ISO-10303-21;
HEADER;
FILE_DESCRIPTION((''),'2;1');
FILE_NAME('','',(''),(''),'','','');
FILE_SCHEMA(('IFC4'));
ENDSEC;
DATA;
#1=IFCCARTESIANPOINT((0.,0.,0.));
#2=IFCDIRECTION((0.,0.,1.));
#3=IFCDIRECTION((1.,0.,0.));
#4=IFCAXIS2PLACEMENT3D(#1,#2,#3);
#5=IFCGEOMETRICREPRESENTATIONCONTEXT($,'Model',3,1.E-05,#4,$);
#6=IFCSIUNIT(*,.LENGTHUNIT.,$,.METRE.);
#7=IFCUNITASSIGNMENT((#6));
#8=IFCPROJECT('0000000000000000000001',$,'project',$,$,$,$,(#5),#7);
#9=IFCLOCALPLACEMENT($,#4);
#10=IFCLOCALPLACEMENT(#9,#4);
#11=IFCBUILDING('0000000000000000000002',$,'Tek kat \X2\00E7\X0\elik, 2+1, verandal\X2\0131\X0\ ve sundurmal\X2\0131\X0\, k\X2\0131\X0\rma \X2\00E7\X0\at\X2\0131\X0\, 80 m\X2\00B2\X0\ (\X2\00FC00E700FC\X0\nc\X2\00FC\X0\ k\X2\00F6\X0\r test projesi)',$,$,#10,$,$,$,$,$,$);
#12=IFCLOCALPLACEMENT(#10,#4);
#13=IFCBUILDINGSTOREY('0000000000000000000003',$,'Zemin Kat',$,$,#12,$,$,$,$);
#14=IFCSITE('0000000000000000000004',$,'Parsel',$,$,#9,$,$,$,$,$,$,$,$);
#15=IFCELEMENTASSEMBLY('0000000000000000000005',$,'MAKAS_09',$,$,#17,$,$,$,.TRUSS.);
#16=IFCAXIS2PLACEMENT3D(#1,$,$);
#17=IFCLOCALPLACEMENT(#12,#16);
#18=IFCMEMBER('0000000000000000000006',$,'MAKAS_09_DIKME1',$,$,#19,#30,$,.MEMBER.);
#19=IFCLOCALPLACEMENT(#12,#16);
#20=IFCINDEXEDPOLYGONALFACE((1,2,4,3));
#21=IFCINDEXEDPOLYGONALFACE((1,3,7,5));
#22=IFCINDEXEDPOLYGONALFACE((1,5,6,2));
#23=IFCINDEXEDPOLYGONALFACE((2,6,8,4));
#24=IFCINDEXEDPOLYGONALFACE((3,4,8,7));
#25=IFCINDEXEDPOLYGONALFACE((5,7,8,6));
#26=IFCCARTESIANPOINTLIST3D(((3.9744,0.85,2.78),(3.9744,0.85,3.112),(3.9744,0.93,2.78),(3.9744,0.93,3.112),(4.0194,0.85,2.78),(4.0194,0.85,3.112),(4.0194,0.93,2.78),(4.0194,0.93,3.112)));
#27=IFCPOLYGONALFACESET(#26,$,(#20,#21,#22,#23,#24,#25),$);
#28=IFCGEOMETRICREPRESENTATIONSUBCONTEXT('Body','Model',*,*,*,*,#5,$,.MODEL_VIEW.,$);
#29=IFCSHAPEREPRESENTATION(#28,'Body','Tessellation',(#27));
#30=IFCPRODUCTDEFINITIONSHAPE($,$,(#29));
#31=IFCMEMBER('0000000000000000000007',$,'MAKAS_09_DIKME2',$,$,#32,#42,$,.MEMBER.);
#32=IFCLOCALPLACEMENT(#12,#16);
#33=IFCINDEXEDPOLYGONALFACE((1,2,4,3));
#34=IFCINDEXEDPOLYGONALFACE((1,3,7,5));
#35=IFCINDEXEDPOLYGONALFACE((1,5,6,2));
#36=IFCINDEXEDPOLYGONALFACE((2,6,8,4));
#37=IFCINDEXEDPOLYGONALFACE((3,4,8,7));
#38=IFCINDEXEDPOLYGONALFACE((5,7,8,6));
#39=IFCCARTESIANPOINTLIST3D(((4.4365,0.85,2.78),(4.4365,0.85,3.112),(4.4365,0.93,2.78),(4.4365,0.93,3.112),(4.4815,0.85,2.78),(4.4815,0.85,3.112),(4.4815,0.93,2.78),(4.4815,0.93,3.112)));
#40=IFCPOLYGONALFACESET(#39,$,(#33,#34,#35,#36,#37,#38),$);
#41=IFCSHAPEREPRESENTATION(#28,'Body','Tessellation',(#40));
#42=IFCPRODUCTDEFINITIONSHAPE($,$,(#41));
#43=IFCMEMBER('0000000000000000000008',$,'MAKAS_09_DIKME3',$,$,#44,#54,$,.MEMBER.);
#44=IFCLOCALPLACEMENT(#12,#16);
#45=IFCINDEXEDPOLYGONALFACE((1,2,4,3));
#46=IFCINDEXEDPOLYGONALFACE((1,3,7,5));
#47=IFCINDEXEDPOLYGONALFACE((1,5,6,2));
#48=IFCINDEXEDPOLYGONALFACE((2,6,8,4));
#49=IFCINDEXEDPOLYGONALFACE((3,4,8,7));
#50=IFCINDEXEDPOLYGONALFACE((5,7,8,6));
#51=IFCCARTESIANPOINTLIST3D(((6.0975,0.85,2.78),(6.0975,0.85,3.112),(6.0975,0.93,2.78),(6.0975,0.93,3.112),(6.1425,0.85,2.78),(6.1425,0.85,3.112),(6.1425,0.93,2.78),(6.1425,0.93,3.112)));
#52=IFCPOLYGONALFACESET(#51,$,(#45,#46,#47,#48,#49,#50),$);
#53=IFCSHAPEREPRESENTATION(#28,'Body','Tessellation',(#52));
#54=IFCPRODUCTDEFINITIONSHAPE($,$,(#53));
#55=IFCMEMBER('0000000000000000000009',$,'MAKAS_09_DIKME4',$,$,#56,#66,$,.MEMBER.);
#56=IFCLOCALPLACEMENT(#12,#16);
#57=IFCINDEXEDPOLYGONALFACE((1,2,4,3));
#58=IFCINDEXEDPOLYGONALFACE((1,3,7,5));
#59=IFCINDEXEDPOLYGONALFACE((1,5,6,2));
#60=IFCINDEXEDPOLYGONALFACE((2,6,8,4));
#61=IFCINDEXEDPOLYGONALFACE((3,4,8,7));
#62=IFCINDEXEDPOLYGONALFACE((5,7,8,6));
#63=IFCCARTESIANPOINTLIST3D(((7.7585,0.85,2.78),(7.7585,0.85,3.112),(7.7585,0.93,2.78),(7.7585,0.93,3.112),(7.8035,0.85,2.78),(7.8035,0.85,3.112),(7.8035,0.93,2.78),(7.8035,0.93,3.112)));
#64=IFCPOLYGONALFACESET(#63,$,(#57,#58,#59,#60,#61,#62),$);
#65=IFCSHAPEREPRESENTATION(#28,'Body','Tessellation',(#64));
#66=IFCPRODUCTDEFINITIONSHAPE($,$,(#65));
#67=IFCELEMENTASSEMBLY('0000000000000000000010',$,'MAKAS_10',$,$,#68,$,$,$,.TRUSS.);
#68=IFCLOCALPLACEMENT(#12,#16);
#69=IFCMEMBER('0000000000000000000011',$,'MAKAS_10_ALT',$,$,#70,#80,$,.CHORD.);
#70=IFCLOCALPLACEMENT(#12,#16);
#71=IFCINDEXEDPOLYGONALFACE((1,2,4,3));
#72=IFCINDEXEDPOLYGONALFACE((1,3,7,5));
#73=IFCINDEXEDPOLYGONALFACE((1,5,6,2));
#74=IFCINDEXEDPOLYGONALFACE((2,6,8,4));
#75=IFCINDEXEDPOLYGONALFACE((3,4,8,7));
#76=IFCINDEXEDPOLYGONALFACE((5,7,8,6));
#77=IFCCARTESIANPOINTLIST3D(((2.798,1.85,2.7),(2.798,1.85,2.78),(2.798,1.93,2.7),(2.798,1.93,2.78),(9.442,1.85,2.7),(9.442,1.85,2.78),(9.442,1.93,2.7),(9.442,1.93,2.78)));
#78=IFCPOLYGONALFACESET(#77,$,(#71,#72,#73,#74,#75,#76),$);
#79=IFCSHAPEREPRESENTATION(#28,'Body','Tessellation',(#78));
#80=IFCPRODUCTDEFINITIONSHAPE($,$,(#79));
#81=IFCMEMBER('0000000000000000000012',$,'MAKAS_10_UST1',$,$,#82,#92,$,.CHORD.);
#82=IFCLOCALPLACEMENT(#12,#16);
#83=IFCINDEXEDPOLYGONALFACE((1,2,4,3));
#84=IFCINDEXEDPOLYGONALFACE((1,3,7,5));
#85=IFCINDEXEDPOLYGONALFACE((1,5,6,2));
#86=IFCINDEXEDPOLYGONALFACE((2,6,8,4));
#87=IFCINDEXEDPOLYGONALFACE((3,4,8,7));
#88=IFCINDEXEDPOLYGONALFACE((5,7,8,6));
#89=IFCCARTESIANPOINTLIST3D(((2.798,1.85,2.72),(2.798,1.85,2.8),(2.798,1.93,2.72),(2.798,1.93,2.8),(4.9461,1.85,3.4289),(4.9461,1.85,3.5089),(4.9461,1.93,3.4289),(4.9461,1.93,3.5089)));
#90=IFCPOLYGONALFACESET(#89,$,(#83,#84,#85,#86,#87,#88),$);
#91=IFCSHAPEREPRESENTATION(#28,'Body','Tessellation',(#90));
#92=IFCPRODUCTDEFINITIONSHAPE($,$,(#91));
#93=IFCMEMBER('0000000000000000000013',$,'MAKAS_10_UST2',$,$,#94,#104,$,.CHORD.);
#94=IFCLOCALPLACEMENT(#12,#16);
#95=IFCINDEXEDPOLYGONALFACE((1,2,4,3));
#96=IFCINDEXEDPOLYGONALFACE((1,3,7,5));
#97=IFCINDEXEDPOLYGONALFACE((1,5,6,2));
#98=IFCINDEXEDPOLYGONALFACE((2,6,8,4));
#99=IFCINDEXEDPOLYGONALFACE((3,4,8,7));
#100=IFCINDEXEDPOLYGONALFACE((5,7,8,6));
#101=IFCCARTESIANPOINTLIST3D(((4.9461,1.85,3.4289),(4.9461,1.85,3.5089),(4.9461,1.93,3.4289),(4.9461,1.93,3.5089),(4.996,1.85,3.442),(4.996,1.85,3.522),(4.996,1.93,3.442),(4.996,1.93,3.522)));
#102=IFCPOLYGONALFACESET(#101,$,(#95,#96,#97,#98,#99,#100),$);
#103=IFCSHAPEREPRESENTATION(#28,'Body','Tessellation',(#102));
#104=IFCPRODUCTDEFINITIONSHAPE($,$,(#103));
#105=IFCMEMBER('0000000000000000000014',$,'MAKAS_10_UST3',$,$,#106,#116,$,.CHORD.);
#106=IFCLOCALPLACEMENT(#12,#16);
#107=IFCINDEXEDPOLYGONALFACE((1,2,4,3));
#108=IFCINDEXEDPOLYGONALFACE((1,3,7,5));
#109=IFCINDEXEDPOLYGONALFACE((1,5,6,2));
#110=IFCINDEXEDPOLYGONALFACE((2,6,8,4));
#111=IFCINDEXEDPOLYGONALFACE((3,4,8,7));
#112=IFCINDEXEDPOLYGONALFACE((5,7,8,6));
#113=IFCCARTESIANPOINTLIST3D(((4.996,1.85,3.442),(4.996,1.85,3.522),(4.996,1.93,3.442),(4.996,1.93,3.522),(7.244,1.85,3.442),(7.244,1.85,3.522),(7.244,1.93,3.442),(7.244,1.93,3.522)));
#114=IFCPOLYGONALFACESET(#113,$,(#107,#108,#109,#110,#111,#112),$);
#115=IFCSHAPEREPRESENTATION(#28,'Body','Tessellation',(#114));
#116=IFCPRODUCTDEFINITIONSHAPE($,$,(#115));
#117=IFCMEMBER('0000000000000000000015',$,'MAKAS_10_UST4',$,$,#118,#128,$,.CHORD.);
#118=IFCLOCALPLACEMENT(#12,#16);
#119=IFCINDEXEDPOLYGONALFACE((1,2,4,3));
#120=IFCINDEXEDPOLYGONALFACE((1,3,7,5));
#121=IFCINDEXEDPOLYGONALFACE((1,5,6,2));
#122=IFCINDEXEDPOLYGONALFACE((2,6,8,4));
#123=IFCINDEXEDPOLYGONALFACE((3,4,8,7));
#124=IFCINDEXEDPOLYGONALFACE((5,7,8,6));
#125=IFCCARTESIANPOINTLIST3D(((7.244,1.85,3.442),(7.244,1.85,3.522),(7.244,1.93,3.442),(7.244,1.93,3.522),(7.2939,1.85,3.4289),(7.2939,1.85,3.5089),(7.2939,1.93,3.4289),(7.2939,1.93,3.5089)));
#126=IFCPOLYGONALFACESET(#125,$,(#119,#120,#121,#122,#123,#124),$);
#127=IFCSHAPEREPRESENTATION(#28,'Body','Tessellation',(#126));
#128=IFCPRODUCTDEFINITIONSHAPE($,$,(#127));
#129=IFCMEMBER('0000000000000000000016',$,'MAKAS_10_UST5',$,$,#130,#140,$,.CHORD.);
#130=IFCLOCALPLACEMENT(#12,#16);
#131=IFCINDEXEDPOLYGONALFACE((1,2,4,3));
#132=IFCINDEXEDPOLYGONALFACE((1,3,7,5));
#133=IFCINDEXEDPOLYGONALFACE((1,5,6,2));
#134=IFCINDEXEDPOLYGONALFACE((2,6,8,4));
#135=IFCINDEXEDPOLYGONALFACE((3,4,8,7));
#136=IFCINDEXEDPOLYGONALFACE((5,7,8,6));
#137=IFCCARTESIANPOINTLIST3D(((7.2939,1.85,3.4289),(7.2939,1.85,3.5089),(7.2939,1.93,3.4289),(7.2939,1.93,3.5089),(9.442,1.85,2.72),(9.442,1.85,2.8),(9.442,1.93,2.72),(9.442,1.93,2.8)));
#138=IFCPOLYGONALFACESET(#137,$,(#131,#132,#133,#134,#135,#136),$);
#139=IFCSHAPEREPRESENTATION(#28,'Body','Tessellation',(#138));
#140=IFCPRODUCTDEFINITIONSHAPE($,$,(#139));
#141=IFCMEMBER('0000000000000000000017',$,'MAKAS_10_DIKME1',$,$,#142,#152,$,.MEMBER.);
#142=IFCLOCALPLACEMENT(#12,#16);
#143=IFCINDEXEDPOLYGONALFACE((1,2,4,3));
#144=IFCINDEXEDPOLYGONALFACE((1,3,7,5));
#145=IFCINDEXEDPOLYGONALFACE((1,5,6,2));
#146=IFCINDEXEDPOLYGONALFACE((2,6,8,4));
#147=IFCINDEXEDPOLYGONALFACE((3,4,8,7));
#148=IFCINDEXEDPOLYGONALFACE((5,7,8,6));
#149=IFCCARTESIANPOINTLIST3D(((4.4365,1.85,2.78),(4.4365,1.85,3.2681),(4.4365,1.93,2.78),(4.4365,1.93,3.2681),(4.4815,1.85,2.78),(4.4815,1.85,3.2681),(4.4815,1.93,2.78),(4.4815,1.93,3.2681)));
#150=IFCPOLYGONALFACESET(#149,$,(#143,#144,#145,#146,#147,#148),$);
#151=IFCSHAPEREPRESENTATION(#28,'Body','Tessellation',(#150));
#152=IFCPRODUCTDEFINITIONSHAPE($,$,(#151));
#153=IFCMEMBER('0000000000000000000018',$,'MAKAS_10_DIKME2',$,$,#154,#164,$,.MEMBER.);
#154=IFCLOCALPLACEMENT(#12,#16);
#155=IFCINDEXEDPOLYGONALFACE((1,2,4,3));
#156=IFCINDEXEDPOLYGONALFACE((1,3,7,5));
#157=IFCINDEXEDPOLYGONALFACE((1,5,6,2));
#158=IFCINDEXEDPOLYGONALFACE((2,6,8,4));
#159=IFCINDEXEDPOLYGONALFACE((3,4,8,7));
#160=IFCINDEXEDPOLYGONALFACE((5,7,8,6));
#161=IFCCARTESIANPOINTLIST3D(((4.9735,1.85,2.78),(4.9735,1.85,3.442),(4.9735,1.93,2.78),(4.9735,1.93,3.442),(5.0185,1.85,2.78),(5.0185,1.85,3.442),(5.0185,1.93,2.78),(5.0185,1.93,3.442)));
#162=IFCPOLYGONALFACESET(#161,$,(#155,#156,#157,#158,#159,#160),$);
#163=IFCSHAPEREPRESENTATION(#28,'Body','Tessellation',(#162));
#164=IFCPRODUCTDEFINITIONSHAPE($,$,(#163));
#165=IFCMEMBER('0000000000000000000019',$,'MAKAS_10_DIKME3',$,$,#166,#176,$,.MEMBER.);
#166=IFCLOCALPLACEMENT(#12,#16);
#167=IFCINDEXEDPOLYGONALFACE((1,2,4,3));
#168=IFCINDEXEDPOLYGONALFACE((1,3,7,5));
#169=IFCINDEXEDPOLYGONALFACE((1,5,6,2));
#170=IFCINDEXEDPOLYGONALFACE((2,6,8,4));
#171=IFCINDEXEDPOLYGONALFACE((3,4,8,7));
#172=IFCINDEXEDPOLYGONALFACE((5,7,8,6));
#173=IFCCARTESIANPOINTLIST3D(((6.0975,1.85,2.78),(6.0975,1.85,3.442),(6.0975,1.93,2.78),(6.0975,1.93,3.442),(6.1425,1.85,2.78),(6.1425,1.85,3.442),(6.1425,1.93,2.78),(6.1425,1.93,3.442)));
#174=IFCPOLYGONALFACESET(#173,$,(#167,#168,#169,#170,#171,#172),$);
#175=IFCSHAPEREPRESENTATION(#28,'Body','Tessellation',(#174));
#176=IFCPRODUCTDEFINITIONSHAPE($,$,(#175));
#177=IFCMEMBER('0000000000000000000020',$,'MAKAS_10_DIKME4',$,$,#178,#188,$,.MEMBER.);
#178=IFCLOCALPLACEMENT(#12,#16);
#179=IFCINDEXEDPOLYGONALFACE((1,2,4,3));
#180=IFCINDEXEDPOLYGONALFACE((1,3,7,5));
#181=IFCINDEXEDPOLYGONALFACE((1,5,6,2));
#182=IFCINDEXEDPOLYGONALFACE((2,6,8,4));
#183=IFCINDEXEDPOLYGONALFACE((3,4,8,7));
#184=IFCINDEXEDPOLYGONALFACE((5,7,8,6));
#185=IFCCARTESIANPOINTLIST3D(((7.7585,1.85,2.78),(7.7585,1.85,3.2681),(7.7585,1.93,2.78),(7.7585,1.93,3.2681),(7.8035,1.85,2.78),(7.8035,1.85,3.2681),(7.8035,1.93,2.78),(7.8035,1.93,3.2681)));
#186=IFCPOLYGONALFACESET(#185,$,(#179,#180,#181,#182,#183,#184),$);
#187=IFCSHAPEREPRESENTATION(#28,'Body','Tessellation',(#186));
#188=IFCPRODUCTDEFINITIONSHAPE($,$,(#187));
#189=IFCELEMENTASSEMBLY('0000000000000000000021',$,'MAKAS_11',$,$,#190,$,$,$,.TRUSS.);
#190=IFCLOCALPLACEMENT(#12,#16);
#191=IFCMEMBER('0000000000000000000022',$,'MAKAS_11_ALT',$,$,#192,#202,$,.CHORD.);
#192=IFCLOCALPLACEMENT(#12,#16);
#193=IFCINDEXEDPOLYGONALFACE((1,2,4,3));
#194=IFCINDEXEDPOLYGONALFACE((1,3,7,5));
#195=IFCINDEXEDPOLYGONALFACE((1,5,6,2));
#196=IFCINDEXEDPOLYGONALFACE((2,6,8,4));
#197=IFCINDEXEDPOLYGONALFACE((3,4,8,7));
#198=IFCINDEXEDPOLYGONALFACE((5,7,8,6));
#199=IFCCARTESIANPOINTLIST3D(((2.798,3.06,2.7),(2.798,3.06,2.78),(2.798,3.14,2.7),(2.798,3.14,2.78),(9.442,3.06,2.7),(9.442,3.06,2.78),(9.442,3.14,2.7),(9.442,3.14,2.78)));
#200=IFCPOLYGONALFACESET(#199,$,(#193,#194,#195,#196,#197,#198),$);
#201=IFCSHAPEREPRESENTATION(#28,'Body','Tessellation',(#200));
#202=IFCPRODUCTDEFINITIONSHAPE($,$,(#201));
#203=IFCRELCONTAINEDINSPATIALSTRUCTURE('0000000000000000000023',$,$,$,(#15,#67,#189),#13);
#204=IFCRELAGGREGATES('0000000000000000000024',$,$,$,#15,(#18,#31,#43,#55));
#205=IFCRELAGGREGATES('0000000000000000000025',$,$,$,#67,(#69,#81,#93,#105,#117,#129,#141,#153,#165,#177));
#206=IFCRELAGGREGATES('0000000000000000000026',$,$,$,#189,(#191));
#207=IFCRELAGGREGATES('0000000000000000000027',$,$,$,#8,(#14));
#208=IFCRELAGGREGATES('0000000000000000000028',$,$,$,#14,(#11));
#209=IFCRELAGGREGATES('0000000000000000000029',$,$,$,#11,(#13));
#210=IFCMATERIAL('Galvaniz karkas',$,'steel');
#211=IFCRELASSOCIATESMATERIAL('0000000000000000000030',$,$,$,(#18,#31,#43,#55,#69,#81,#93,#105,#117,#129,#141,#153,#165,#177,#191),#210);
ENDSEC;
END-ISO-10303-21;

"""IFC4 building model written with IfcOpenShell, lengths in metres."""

from ifc_helpers import new_model, si_unit, frame, origin_with_axes, place, context, subcontext, project, spatial, line, indexed_curve, outline, extrude, material, element, aggregate, save


model = new_model("IFC4")

# Units and contexts
model_context = context("Model", 3, precision=1e-05, world=origin_with_axes())
body_context = subcontext(model_context, "Body", "Model", "MODEL_VIEW")
ifc_project = project(units=[si_unit("LENGTHUNIT", "METRE")], contexts=[model_context])

# Site, building, storey
site_placement = place(None, origin_with_axes())
site = spatial("IfcSite", under=ifc_project, at=site_placement, Name="Parsel")
building_placement = place(site_placement, origin_with_axes())
building = spatial("IfcBuilding", under=site, at=building_placement, Name="Tek kat çelik, 2+1, verandalı ve sundurmalı, kırma çatı, 80 m² (üçüncü kör test projesi)")
storey_placement = place(building_placement, origin_with_axes())
storey = spatial("IfcBuildingStorey", under=building, at=storey_placement, Name="Zemin Kat")

# Element assemblies, members
ifc_material = material(Name="Galvaniz karkas", Category="steel")
assembly_1_placement = place(storey_placement, origin_with_axes())
assembly_1 = element("IfcElementAssembly", 1, at=assembly_1_placement, inside=storey, Name="MAKAS_09", PredefinedType="TRUSS")
member_1_placement = place(assembly_1_placement, origin_with_axes())
member_1 = element("IfcMember", 2, at=member_1_placement, material=ifc_material, Name="MAKAS_09_DIKME1", PredefinedType="MEMBER", context=body_context, shape_type="SweptSolid", body=[
    extrude(outline(indexed_curve([(3.9744, 2.78), (4.0194, 2.78), (4.0194, 3.112), (3.9744, 3.112)], segments=[line(1, 2, 3, 4, 1)])), frame((0.0, 0.93, 0.0), z_axis=(0.0, -1.0, 0.0), x_axis=(1.0, 0.0, 0.0)), (0.0, 0.0, 1.0), 0.08),
])
member_2_placement = place(assembly_1_placement, origin_with_axes())
member_2 = element("IfcMember", 3, at=member_2_placement, material=ifc_material, Name="MAKAS_09_DIKME2", PredefinedType="MEMBER", context=body_context, shape_type="SweptSolid", body=[
    extrude(outline(indexed_curve([(4.4365, 2.78), (4.4815, 2.78), (4.4815, 3.112), (4.4365, 3.112)], segments=[line(1, 2, 3, 4, 1)])), frame((0.0, 0.93, 0.0), z_axis=(0.0, -1.0, 0.0), x_axis=(1.0, 0.0, 0.0)), (0.0, 0.0, 1.0), 0.08),
])
member_3_placement = place(assembly_1_placement, origin_with_axes())
member_3 = element("IfcMember", 4, at=member_3_placement, material=ifc_material, Name="MAKAS_09_DIKME3", PredefinedType="MEMBER", context=body_context, shape_type="SweptSolid", body=[
    extrude(outline(indexed_curve([(6.0975, 2.78), (6.1425, 2.78), (6.1425, 3.112), (6.0975, 3.112)], segments=[line(1, 2, 3, 4, 1)])), frame((0.0, 0.93, 0.0), z_axis=(0.0, -1.0, 0.0), x_axis=(1.0, 0.0, 0.0)), (0.0, 0.0, 1.0), 0.08),
])
member_4_placement = place(assembly_1_placement, origin_with_axes())
member_4 = element("IfcMember", 5, at=member_4_placement, material=ifc_material, Name="MAKAS_09_DIKME4", PredefinedType="MEMBER", context=body_context, shape_type="SweptSolid", body=[
    extrude(outline(indexed_curve([(7.7585, 2.78), (7.8035, 2.78), (7.8035, 3.112), (7.7585, 3.112)], segments=[line(1, 2, 3, 4, 1)])), frame((0.0, 0.93, 0.0), z_axis=(0.0, -1.0, 0.0), x_axis=(1.0, 0.0, 0.0)), (0.0, 0.0, 1.0), 0.08),
])
aggregate(assembly_1, [member_1, member_2, member_3, member_4])
assembly_2_placement = place(storey_placement, origin_with_axes())
assembly_2 = element("IfcElementAssembly", 6, at=assembly_2_placement, inside=storey, Name="MAKAS_10", PredefinedType="TRUSS")
member_5_placement = place(assembly_2_placement, origin_with_axes())
member_5 = element("IfcMember", 7, at=member_5_placement, material=ifc_material, Name="MAKAS_10_ALT", PredefinedType="CHORD", context=body_context, shape_type="SweptSolid", body=[
    extrude(outline(indexed_curve([(2.798, 2.7), (9.442, 2.7), (9.442, 2.78), (2.798, 2.78)], segments=[line(1, 2, 3, 4, 1)])), frame((0.0, 1.93, 0.0), z_axis=(0.0, -1.0, 0.0), x_axis=(1.0, 0.0, 0.0)), (0.0, 0.0, 1.0), 0.08),
])
member_6_placement = place(assembly_2_placement, origin_with_axes())
member_6 = element("IfcMember", 8, at=member_6_placement, material=ifc_material, Name="MAKAS_10_UST1", PredefinedType="CHORD", context=body_context, shape_type="SweptSolid", body=[
    extrude(outline(indexed_curve([(2.798, 2.72), (4.9461, 3.4289), (4.9461, 3.5089), (2.798, 2.8)], segments=[line(1, 2, 3, 4, 1)])), frame((0.0, 1.93, 0.0), z_axis=(0.0, -1.0, 0.0), x_axis=(1.0, 0.0, 0.0)), (0.0, 0.0, 1.0), 0.08),
])
member_7_placement = place(assembly_2_placement, origin_with_axes())
member_7 = element("IfcMember", 9, at=member_7_placement, material=ifc_material, Name="MAKAS_10_UST2", PredefinedType="CHORD", context=body_context, shape_type="SweptSolid", body=[
    extrude(outline(indexed_curve([(4.9461, 3.4289), (4.996, 3.442), (4.996, 3.522), (4.9461, 3.5089)], segments=[line(1, 2, 3, 4, 1)])), frame((0.0, 1.93, 0.0), z_axis=(0.0, -1.0, 0.0), x_axis=(1.0, 0.0, 0.0)), (0.0, 0.0, 1.0), 0.08),
])
member_8_placement = place(assembly_2_placement, origin_with_axes())
member_8 = element("IfcMember", 10, at=member_8_placement, material=ifc_material, Name="MAKAS_10_UST3", PredefinedType="CHORD", context=body_context, shape_type="SweptSolid", body=[
    extrude(outline(indexed_curve([(4.996, 3.442), (7.244, 3.442), (7.244, 3.522), (4.996, 3.522)], segments=[line(1, 2, 3, 4, 1)])), frame((0.0, 1.93, 0.0), z_axis=(0.0, -1.0, 0.0), x_axis=(1.0, 0.0, 0.0)), (0.0, 0.0, 1.0), 0.08),
])
member_9_placement = place(assembly_2_placement, origin_with_axes())
member_9 = element("IfcMember", 11, at=member_9_placement, material=ifc_material, Name="MAKAS_10_UST4", PredefinedType="CHORD", context=body_context, shape_type="SweptSolid", body=[
    extrude(outline(indexed_curve([(7.244, 3.442), (7.2939, 3.4289), (7.2939, 3.5089), (7.244, 3.522)], segments=[line(1, 2, 3, 4, 1)])), frame((0.0, 1.93, 0.0), z_axis=(0.0, -1.0, 0.0), x_axis=(1.0, 0.0, 0.0)), (0.0, 0.0, 1.0), 0.08),
])
member_10_placement = place(assembly_2_placement, origin_with_axes())
member_10 = element("IfcMember", 12, at=member_10_placement, material=ifc_material, Name="MAKAS_10_UST5", PredefinedType="CHORD", context=body_context, shape_type="SweptSolid", body=[
    extrude(outline(indexed_curve([(7.2939, 3.4289), (9.442, 2.72), (9.442, 2.8), (7.2939, 3.5089)], segments=[line(1, 2, 3, 4, 1)])), frame((0.0, 1.93, 0.0), z_axis=(0.0, -1.0, 0.0), x_axis=(1.0, 0.0, 0.0)), (0.0, 0.0, 1.0), 0.08),
])
member_11_placement = place(assembly_2_placement, origin_with_axes())
member_11 = element("IfcMember", 13, at=member_11_placement, material=ifc_material, Name="MAKAS_10_DIKME1", PredefinedType="MEMBER", context=body_context, shape_type="SweptSolid", body=[
    extrude(outline(indexed_curve([(4.4365, 2.78), (4.4815, 2.78), (4.4815, 3.2681), (4.4365, 3.2681)], segments=[line(1, 2, 3, 4, 1)])), frame((0.0, 1.93, 0.0), z_axis=(0.0, -1.0, 0.0), x_axis=(1.0, 0.0, 0.0)), (0.0, 0.0, 1.0), 0.08),
])
member_12_placement = place(assembly_2_placement, origin_with_axes())
member_12 = element("IfcMember", 14, at=member_12_placement, material=ifc_material, Name="MAKAS_10_DIKME2", PredefinedType="MEMBER", context=body_context, shape_type="SweptSolid", body=[
    extrude(outline(indexed_curve([(4.9735, 2.78), (5.0185, 2.78), (5.0185, 3.442), (4.9735, 3.442)], segments=[line(1, 2, 3, 4, 1)])), frame((0.0, 1.93, 0.0), z_axis=(0.0, -1.0, 0.0), x_axis=(1.0, 0.0, 0.0)), (0.0, 0.0, 1.0), 0.08),
])
member_13_placement = place(assembly_2_placement, origin_with_axes())
member_13 = element("IfcMember", 15, at=member_13_placement, material=ifc_material, Name="MAKAS_10_DIKME3", PredefinedType="MEMBER", context=body_context, shape_type="SweptSolid", body=[
    extrude(outline(indexed_curve([(6.0975, 2.78), (6.1425, 2.78), (6.1425, 3.442), (6.0975, 3.442)], segments=[line(1, 2, 3, 4, 1)])), frame((0.0, 1.93, 0.0), z_axis=(0.0, -1.0, 0.0), x_axis=(1.0, 0.0, 0.0)), (0.0, 0.0, 1.0), 0.08),
])
member_14_placement = place(assembly_2_placement, origin_with_axes())
member_14 = element("IfcMember", 16, at=member_14_placement, material=ifc_material, Name="MAKAS_10_DIKME4", PredefinedType="MEMBER", context=body_context, shape_type="SweptSolid", body=[
    extrude(outline(indexed_curve([(7.7585, 2.78), (7.8035, 2.78), (7.8035, 3.2681), (7.7585, 3.2681)], segments=[line(1, 2, 3, 4, 1)])), frame((0.0, 1.93, 0.0), z_axis=(0.0, -1.0, 0.0), x_axis=(1.0, 0.0, 0.0)), (0.0, 0.0, 1.0), 0.08),
])
aggregate(assembly_2, [member_5, member_6, member_7, member_8, member_9, member_10, member_11, member_12, member_13, member_14])
assembly_3_placement = place(storey_placement, origin_with_axes())
assembly_3 = element("IfcElementAssembly", 17, at=assembly_3_placement, inside=storey, Name="MAKAS_11", PredefinedType="TRUSS")
member_15_placement = place(assembly_3_placement, origin_with_axes())
member_15 = element("IfcMember", 18, at=member_15_placement, material=ifc_material, Name="MAKAS_11_ALT", PredefinedType="CHORD", context=body_context, shape_type="SweptSolid", body=[
    extrude(outline(indexed_curve([(2.798, 2.7), (9.442, 2.7), (9.442, 2.78), (2.798, 2.78)], segments=[line(1, 2, 3, 4, 1)])), frame((0.0, 3.14, 0.0), z_axis=(0.0, -1.0, 0.0), x_axis=(1.0, 0.0, 0.0)), (0.0, 0.0, 1.0), 0.08),
])
aggregate(assembly_3, [member_15])

save(model, "model.ifc")
